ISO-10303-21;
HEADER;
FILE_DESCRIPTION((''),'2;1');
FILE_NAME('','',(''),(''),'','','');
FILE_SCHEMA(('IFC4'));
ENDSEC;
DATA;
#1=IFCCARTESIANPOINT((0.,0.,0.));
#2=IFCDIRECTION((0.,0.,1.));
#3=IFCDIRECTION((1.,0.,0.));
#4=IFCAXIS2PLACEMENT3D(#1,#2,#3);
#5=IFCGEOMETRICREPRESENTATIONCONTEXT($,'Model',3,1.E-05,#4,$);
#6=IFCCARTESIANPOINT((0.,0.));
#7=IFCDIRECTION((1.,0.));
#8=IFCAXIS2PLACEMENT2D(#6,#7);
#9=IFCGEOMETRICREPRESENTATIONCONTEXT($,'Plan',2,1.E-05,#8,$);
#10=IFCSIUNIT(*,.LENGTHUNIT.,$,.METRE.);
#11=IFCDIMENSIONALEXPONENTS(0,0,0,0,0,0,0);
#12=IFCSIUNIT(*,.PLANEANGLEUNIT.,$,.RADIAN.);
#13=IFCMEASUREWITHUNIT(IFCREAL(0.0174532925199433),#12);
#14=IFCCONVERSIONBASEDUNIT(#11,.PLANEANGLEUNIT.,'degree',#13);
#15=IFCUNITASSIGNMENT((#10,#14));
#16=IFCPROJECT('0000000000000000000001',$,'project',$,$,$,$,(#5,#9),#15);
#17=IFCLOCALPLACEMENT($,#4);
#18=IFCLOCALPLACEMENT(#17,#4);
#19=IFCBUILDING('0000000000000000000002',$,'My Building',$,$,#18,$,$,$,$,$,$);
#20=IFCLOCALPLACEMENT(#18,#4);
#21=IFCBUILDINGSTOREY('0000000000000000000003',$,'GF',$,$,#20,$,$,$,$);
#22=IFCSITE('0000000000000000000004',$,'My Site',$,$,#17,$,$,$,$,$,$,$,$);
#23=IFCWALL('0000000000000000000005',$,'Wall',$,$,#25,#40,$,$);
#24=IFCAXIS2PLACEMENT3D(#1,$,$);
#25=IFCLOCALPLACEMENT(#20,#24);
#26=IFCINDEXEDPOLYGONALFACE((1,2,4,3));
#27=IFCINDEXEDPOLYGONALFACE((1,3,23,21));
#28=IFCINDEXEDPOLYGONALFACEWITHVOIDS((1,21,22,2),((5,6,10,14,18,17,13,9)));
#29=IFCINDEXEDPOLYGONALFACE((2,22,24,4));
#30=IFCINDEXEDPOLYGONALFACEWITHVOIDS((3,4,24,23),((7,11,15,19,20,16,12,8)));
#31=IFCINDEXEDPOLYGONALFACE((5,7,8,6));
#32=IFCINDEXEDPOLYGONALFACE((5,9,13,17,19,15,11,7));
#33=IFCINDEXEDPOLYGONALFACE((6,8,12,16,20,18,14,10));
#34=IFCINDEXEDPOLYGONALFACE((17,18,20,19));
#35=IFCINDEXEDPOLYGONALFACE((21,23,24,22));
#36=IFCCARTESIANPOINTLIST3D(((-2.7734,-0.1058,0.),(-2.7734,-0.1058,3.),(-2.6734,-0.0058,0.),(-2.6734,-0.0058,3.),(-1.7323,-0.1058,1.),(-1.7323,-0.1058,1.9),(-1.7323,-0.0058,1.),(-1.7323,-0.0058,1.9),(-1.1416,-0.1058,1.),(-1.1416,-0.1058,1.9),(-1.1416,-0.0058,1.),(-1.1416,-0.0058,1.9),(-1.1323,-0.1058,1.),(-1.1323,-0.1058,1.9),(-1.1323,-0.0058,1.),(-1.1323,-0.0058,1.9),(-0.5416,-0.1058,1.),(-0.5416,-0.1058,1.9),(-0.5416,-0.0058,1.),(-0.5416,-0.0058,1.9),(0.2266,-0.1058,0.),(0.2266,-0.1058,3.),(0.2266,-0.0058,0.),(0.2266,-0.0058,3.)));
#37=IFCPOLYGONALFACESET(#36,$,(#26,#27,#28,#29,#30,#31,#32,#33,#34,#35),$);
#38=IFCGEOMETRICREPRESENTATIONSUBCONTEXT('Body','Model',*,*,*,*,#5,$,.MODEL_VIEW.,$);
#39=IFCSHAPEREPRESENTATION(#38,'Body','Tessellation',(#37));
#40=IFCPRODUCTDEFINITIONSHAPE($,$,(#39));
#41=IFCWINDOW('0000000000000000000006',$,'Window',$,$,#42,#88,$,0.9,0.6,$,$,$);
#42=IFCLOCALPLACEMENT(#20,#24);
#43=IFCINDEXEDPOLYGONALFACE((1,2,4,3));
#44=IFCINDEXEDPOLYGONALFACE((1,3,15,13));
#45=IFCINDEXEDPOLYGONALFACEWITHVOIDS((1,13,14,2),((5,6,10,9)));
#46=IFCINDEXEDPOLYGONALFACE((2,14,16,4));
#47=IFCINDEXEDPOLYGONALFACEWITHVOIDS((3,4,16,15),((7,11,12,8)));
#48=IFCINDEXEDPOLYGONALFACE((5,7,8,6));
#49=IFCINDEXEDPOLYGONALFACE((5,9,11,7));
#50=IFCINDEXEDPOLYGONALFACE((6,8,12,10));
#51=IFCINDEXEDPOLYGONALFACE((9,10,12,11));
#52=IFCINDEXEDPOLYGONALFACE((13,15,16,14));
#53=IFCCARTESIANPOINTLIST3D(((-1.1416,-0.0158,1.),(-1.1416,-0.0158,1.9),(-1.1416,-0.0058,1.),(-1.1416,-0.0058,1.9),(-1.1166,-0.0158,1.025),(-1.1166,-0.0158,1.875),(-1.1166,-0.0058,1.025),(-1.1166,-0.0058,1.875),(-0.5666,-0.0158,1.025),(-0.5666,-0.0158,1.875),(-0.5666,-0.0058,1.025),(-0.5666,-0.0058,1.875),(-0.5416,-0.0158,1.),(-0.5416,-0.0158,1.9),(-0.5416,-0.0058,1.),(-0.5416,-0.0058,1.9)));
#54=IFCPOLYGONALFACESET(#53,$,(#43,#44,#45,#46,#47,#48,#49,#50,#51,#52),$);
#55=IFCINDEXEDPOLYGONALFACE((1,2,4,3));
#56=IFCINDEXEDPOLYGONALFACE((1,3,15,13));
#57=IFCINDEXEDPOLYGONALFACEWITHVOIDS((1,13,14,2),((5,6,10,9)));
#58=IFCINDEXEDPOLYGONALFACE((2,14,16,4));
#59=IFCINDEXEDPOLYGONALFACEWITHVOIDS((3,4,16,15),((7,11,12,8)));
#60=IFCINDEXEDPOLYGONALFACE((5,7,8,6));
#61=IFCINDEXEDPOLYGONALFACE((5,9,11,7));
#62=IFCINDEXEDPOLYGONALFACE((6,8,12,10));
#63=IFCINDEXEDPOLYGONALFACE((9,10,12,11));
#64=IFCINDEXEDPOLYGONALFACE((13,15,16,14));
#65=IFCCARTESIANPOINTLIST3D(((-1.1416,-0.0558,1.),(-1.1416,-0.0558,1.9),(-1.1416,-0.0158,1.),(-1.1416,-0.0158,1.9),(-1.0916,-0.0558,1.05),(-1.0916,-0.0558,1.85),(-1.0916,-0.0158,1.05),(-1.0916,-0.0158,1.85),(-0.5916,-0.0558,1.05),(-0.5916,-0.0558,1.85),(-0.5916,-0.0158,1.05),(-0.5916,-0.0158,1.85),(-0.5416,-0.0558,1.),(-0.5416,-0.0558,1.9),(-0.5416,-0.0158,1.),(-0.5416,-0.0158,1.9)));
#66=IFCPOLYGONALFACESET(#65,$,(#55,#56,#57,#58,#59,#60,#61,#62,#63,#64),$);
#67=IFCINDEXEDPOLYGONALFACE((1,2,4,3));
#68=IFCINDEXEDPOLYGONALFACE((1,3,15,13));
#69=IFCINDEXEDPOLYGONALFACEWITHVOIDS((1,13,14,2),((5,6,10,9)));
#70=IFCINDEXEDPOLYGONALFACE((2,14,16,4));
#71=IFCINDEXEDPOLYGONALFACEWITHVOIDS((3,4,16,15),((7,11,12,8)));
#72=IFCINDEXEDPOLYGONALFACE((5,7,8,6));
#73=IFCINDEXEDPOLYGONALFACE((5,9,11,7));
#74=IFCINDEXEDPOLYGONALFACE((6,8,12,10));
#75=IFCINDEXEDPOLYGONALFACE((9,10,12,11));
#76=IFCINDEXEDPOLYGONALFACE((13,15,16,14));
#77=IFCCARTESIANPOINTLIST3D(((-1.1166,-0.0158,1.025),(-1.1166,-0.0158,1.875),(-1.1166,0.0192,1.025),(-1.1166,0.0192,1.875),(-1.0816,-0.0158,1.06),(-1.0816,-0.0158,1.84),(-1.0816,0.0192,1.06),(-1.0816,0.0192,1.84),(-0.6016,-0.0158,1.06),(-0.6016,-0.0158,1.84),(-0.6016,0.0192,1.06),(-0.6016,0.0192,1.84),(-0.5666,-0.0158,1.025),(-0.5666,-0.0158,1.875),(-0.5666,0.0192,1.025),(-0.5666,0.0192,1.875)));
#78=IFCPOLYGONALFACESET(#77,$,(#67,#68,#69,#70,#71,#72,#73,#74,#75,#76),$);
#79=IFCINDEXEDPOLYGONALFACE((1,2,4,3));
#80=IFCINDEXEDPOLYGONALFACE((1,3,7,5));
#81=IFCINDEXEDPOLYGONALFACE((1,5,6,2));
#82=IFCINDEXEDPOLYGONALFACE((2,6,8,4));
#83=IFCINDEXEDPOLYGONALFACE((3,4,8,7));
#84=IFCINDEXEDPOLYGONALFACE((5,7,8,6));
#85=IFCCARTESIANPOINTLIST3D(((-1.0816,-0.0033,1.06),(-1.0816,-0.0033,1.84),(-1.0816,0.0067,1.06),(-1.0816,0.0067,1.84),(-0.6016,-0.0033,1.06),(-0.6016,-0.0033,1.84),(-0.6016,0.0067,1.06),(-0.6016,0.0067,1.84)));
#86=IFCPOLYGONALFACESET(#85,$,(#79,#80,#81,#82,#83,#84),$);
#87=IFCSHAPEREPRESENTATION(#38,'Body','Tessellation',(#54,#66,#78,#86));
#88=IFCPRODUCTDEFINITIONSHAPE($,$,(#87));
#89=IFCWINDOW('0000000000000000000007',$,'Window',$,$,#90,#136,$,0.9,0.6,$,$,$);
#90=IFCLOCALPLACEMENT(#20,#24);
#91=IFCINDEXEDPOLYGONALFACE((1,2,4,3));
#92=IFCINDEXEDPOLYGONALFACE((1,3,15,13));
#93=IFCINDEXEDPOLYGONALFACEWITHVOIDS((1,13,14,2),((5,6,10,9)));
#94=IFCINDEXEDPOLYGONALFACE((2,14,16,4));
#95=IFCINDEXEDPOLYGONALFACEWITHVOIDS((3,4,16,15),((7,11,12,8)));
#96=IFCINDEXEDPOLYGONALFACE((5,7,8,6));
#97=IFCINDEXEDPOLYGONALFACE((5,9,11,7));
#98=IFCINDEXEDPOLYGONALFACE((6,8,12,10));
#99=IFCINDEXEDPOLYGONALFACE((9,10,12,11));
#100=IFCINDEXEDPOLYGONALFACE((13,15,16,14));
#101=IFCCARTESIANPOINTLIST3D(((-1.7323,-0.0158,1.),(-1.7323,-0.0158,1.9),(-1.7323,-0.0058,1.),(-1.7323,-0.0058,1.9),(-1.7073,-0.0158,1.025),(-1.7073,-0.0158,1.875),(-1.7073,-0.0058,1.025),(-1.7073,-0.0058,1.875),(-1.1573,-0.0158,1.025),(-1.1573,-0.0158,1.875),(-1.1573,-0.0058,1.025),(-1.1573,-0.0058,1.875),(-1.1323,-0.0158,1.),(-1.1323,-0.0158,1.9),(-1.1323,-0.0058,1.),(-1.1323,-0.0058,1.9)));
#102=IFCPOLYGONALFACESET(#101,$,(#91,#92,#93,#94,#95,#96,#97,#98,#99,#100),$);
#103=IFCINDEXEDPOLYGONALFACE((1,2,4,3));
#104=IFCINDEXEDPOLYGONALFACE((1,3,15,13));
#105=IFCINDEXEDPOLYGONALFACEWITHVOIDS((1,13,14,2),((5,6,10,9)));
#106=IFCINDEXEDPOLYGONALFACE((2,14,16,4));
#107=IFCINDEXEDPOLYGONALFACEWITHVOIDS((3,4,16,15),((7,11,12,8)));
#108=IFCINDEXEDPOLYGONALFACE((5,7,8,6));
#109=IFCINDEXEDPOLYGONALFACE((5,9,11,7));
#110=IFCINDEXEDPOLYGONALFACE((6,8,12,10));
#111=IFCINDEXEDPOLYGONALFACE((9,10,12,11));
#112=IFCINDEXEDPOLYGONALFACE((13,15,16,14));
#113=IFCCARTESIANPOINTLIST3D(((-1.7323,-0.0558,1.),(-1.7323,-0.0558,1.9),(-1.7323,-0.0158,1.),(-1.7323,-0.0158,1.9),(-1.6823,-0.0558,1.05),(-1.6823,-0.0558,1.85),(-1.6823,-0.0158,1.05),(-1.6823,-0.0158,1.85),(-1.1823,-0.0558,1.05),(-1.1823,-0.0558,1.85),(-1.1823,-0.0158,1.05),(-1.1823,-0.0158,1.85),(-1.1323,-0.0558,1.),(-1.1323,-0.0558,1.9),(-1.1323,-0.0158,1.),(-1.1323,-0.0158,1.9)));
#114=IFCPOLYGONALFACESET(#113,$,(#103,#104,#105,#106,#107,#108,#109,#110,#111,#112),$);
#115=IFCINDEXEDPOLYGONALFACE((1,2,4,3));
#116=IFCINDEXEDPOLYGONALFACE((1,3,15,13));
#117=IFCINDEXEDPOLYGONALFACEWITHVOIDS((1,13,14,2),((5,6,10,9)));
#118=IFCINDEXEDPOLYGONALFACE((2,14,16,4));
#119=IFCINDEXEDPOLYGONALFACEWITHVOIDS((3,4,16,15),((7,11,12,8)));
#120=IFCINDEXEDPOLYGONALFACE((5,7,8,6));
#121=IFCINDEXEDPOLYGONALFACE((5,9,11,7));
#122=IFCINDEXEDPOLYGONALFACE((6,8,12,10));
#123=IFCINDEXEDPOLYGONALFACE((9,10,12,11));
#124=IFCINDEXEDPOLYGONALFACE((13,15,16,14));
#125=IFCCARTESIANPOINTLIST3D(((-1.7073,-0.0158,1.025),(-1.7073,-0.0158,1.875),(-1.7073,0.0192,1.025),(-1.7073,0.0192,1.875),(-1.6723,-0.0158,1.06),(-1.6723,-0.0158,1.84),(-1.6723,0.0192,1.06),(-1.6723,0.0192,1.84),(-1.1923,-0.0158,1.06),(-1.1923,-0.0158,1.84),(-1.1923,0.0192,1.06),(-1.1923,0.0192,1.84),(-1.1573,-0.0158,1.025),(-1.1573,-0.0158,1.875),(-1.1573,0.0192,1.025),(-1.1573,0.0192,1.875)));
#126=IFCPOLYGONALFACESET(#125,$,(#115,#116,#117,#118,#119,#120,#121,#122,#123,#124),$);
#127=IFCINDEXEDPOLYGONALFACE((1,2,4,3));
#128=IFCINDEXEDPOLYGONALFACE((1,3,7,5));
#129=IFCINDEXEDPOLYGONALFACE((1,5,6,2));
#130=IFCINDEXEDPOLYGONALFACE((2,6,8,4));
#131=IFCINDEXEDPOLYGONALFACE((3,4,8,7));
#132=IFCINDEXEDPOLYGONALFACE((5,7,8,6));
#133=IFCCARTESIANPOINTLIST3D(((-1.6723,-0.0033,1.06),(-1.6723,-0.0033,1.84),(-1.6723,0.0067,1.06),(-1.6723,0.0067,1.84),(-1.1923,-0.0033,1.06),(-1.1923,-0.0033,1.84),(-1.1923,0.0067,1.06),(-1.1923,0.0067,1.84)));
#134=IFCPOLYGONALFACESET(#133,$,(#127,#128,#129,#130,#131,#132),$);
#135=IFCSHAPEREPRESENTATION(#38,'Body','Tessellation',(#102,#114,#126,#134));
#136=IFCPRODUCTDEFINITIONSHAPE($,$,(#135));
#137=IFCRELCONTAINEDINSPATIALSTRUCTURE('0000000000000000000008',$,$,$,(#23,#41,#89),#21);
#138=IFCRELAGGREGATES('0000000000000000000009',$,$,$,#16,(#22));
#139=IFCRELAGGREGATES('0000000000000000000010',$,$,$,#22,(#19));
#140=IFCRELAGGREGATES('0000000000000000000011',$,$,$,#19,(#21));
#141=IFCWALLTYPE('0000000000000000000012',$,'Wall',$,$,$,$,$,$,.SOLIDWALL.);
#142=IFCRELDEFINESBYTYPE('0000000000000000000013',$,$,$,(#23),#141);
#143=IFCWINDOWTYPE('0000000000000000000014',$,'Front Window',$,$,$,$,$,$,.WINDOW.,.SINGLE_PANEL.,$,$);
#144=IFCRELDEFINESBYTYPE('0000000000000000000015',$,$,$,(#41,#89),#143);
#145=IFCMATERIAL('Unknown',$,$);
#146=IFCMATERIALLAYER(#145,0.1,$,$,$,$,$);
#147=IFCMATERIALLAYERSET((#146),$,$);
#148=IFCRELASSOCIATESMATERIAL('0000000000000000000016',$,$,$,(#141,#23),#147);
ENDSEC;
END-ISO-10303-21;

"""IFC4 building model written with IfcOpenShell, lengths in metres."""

from ifc_helpers import new_model, entity, si_unit, converted_unit, frame, origin_with_axes, origin_2d_with_axis, place, context, subcontext, project, spatial, line, indexed_curve, outline, extrude, shape, source, transform, mapped, material, layer, layer_set, layer_usage, type_object, type_shapes, element, fill, save


model = new_model("IFC4")

# Units and contexts
model_context = context("Model", 3, precision=1e-05, world=origin_with_axes())
plan_context = context("Plan", 2, precision=1e-05, world=origin_2d_with_axis())
body_context_1 = subcontext(model_context, "Body", "Model", "MODEL_VIEW")
body_context_2 = subcontext(plan_context, "Body", "Plan", "PLAN_VIEW")
ifc_project = project(units=[si_unit("LENGTHUNIT", "METRE"), converted_unit("PLANEANGLEUNIT", "degree", entity("IfcReal", 0.0174532925199433), si_unit("PLANEANGLEUNIT", "RADIAN"), dimensions=[0, 0, 0, 0, 0, 0, 0])], contexts=[model_context, plan_context])

# Site, building, storey
site_placement = place(None, origin_with_axes())
site = spatial("IfcSite", under=ifc_project, at=site_placement, Name="My Site")
building_placement = place(site_placement, origin_with_axes())
building = spatial("IfcBuilding", under=site, at=building_placement, Name="My Building")
storey_placement = place(building_placement, origin_with_axes())
storey = spatial("IfcBuildingStorey", under=building, at=storey_placement, Name="GF")

# Shared definitions
ifc_material = material(Name="Unknown")

# Shared definitions
ifc_layer_1 = layer(ifc_material, 0.1)
ifc_layer_set_1 = layer_set([ifc_layer_1])
wall_type = type_object("IfcWallType", Name="Wall", PredefinedType="SOLIDWALL", material=ifc_layer_set_1)
shared_shape_1 = source(origin_with_axes(), body_context_1, "Body", "SweptSolid", [
    extrude(outline(indexed_curve([(0.0, 0.0), (0.6, 0.0), (0.6, 0.9), (0.0, 0.9)], segments=[line(1, 2, 3, 4, 1)])), frame((0.0, -0.6, 0.0), z_axis=(0.0, -1.0, 0.0), x_axis=(1.0, 0.0, 0.0)), (0.0, 0.0, -1.0), 1.2),
])
window_type_1 = type_object("IfcWindowType", Name="Front Window", PartitioningType="SINGLE_PANEL", PredefinedType="WINDOW")
shared_shape_2 = source(origin_with_axes(), body_context_1, "Body", "SweptSolid", [
    extrude(outline(indexed_curve([(0.0, 0.0), (0.6, 0.0), (0.6, 0.9), (0.0, 0.9)], segments=[line(1, 2, 3, 4, 1)]), holes=[indexed_curve([(0.025, 0.025), (0.575, 0.025), (0.575, 0.875), (0.025, 0.875)], segments=[line(1, 2, 3, 4, 1)])]), frame((0.0, 0.09, 0.0), z_axis=(0.0, -1.0, 0.0), x_axis=(1.0, 0.0, 0.0)), (0.0, 0.0, -1.0), 0.01),
    extrude(outline(indexed_curve([(0.0, 0.0), (0.6, 0.0), (0.6, 0.9), (0.0, 0.9)], segments=[line(1, 2, 3, 4, 1)]), holes=[indexed_curve([(0.05, 0.05), (0.55, 0.05), (0.55, 0.85), (0.05, 0.85)], segments=[line(1, 2, 3, 4, 1)])]), frame((0.0, 0.05, 0.0), z_axis=(0.0, -1.0, 0.0), x_axis=(1.0, 0.0, 0.0)), (0.0, 0.0, -1.0), 0.04),
    extrude(outline(indexed_curve([(0.0, 0.0), (0.55, 0.0), (0.55, 0.85), (0.0, 0.85)], segments=[line(1, 2, 3, 4, 1)]), holes=[indexed_curve([(0.035, 0.035), (0.515, 0.035), (0.515, 0.815), (0.035, 0.815)], segments=[line(1, 2, 3, 4, 1)])]), frame((0.025, 0.09, 0.025), z_axis=(0.0, -1.0, 0.0), x_axis=(1.0, 0.0, 0.0)), (0.0, 0.0, -1.0), 0.035),
    extrude(outline(indexed_curve([(0.035, 0.035), (0.515, 0.035), (0.515, 0.815), (0.035, 0.815)], segments=[line(1, 2, 3, 4, 1)])), frame((0.025, 0.1025, 0.025), z_axis=(0.0, -1.0, 0.0), x_axis=(1.0, 0.0, 0.0)), (0.0, 0.0, -1.0), 0.01),
])
shared_shape_3 = source(origin_with_axes(), body_context_2, "Body", "Curve2D", [
    entity("IfcIndexedPolyCurve", entity("IfcCartesianPointList2D", [[0.05, 0.05], [0.55, 0.05]])),
    entity("IfcIndexedPolyCurve", entity("IfcCartesianPointList2D", [[0.0, 0.1], [0.025, 0.1], [0.025, 0.09], [0.05, 0.09], [0.05, 0.05], [0.0, 0.05]]), [entity("IfcLineIndex", [1, 2, 3, 4, 5, 6, 1])]),
    entity("IfcIndexedPolyCurve", entity("IfcCartesianPointList2D", [[0.6, 0.1], [0.575, 0.1], [0.575, 0.09], [0.55, 0.09], [0.55, 0.05], [0.6, 0.05]]), [entity("IfcLineIndex", [1, 2, 3, 4, 5, 6, 1])]),
    entity("IfcIndexedPolyCurve", entity("IfcCartesianPointList2D", [[0.025, 0.09], [0.06, 0.09], [0.06, 0.125], [0.025, 0.125]]), [entity("IfcLineIndex", [1, 2, 3, 4, 1])]),
    entity("IfcIndexedPolyCurve", entity("IfcCartesianPointList2D", [[0.575, 0.09], [0.54, 0.09], [0.54, 0.125], [0.575, 0.125]]), [entity("IfcLineIndex", [1, 2, 3, 4, 1])]),
    entity("IfcIndexedPolyCurve", entity("IfcCartesianPointList2D", [[0.06, 0.09], [0.54, 0.09]])),
    entity("IfcIndexedPolyCurve", entity("IfcCartesianPointList2D", [[0.06, 0.125], [0.54, 0.125]])),
    entity("IfcIndexedPolyCurve", entity("IfcCartesianPointList2D", [[0.06, 0.1075], [0.54, 0.1075]])),
])
type_shapes(window_type_1, [shared_shape_2, shared_shape_3])

# Wall, openings, windows
ifc_layer_usage_1 = layer_usage(ifc_layer_set_1, "AXIS2", "POSITIVE", 0.0)
wall_1_placement = place(storey_placement, frame((-2.7734, -0.1058, 0.0), z_axis=(0.0, 0.0, 1.0), x_axis=(1.0, 0.0, 0.0)))
wall_1 = element("IfcWall", 1, at=wall_1_placement, inside=storey, type_object=wall_type, material=ifc_layer_usage_1, Name="Wall", context=body_context_1, shape_type="SweptSolid", body=[
    extrude(outline(indexed_curve([(0.0, 0.0), (0.1, 0.1), (3.0, 0.1), (3.0, 0.0)], segments=[line(1, 2, 3, 4, 1)])), origin_with_axes(), (0.0, 0.0, 1.0), 3.0),
])
opening_1_placement = place(wall_1_placement, frame((1.6318, 0.0, 1.0), z_axis=(0.0, 0.0, 1.0), x_axis=(1.0, 0.0, 0.0)))
opening_1 = element("IfcOpeningElement", 2, at=opening_1_placement, cuts=wall_1, PredefinedType="OPENING", context=body_context_1, shape_type="MappedRepresentation", body=[
    mapped(shared_shape_1, transform((0.0, 0.0, 0.0), x_axis=(1.0, 0.0, 0.0), y_axis=(0.0, 1.0, 0.0), z_axis=(0.0, 0.0, 1.0), scale=1.0)),
])
opening_2_placement = place(wall_1_placement, frame((1.0411, 0.0, 1.0), z_axis=(0.0, 0.0, 1.0), x_axis=(1.0, 0.0, 0.0)))
opening_2 = element("IfcOpeningElement", 3, at=opening_2_placement, cuts=wall_1, PredefinedType="OPENING", context=body_context_1, shape_type="MappedRepresentation", body=[
    mapped(shared_shape_1, transform((0.0, 0.0, 0.0), x_axis=(1.0, 0.0, 0.0), y_axis=(0.0, 1.0, 0.0), z_axis=(0.0, 0.0, 1.0), scale=1.0)),
])
window_1_placement = place(opening_1_placement, origin_with_axes())
window_1 = element("IfcWindow", 4, at=window_1_placement, inside=storey, type_object=window_type_1, Name="Window", OverallHeight=0.9, OverallWidth=0.6, shapes=[
    shape(body_context_1, "Body", "MappedRepresentation", [mapped(shared_shape_2, transform((0.0, 0.0, 0.0), x_axis=(1.0, 0.0, 0.0), y_axis=(0.0, 1.0, 0.0), z_axis=(0.0, 0.0, 1.0), scale=1.0))]),
    shape(body_context_2, "Body", "MappedRepresentation", [mapped(shared_shape_3, transform((0.0, 0.0, 0.0), x_axis=(1.0, 0.0, 0.0), y_axis=(0.0, 1.0, 0.0), z_axis=(0.0, 0.0, 1.0), scale=1.0))]),
])
fill(opening_1, window_1)
window_2_placement = place(opening_2_placement, origin_with_axes())
window_2 = element("IfcWindow", 5, at=window_2_placement, inside=storey, type_object=window_type_1, Name="Window", OverallHeight=0.9, OverallWidth=0.6, shapes=[
    shape(body_context_1, "Body", "MappedRepresentation", [mapped(shared_shape_2, transform((0.0, 0.0, 0.0), x_axis=(1.0, 0.0, 0.0), y_axis=(0.0, 1.0, 0.0), z_axis=(0.0, 0.0, 1.0), scale=1.0))]),
    shape(body_context_2, "Body", "MappedRepresentation", [mapped(shared_shape_3, transform((0.0, 0.0, 0.0), x_axis=(1.0, 0.0, 0.0), y_axis=(0.0, 1.0, 0.0), z_axis=(0.0, 0.0, 1.0), scale=1.0))]),
])
fill(opening_2, window_2)

save(model, "model.ifc")
